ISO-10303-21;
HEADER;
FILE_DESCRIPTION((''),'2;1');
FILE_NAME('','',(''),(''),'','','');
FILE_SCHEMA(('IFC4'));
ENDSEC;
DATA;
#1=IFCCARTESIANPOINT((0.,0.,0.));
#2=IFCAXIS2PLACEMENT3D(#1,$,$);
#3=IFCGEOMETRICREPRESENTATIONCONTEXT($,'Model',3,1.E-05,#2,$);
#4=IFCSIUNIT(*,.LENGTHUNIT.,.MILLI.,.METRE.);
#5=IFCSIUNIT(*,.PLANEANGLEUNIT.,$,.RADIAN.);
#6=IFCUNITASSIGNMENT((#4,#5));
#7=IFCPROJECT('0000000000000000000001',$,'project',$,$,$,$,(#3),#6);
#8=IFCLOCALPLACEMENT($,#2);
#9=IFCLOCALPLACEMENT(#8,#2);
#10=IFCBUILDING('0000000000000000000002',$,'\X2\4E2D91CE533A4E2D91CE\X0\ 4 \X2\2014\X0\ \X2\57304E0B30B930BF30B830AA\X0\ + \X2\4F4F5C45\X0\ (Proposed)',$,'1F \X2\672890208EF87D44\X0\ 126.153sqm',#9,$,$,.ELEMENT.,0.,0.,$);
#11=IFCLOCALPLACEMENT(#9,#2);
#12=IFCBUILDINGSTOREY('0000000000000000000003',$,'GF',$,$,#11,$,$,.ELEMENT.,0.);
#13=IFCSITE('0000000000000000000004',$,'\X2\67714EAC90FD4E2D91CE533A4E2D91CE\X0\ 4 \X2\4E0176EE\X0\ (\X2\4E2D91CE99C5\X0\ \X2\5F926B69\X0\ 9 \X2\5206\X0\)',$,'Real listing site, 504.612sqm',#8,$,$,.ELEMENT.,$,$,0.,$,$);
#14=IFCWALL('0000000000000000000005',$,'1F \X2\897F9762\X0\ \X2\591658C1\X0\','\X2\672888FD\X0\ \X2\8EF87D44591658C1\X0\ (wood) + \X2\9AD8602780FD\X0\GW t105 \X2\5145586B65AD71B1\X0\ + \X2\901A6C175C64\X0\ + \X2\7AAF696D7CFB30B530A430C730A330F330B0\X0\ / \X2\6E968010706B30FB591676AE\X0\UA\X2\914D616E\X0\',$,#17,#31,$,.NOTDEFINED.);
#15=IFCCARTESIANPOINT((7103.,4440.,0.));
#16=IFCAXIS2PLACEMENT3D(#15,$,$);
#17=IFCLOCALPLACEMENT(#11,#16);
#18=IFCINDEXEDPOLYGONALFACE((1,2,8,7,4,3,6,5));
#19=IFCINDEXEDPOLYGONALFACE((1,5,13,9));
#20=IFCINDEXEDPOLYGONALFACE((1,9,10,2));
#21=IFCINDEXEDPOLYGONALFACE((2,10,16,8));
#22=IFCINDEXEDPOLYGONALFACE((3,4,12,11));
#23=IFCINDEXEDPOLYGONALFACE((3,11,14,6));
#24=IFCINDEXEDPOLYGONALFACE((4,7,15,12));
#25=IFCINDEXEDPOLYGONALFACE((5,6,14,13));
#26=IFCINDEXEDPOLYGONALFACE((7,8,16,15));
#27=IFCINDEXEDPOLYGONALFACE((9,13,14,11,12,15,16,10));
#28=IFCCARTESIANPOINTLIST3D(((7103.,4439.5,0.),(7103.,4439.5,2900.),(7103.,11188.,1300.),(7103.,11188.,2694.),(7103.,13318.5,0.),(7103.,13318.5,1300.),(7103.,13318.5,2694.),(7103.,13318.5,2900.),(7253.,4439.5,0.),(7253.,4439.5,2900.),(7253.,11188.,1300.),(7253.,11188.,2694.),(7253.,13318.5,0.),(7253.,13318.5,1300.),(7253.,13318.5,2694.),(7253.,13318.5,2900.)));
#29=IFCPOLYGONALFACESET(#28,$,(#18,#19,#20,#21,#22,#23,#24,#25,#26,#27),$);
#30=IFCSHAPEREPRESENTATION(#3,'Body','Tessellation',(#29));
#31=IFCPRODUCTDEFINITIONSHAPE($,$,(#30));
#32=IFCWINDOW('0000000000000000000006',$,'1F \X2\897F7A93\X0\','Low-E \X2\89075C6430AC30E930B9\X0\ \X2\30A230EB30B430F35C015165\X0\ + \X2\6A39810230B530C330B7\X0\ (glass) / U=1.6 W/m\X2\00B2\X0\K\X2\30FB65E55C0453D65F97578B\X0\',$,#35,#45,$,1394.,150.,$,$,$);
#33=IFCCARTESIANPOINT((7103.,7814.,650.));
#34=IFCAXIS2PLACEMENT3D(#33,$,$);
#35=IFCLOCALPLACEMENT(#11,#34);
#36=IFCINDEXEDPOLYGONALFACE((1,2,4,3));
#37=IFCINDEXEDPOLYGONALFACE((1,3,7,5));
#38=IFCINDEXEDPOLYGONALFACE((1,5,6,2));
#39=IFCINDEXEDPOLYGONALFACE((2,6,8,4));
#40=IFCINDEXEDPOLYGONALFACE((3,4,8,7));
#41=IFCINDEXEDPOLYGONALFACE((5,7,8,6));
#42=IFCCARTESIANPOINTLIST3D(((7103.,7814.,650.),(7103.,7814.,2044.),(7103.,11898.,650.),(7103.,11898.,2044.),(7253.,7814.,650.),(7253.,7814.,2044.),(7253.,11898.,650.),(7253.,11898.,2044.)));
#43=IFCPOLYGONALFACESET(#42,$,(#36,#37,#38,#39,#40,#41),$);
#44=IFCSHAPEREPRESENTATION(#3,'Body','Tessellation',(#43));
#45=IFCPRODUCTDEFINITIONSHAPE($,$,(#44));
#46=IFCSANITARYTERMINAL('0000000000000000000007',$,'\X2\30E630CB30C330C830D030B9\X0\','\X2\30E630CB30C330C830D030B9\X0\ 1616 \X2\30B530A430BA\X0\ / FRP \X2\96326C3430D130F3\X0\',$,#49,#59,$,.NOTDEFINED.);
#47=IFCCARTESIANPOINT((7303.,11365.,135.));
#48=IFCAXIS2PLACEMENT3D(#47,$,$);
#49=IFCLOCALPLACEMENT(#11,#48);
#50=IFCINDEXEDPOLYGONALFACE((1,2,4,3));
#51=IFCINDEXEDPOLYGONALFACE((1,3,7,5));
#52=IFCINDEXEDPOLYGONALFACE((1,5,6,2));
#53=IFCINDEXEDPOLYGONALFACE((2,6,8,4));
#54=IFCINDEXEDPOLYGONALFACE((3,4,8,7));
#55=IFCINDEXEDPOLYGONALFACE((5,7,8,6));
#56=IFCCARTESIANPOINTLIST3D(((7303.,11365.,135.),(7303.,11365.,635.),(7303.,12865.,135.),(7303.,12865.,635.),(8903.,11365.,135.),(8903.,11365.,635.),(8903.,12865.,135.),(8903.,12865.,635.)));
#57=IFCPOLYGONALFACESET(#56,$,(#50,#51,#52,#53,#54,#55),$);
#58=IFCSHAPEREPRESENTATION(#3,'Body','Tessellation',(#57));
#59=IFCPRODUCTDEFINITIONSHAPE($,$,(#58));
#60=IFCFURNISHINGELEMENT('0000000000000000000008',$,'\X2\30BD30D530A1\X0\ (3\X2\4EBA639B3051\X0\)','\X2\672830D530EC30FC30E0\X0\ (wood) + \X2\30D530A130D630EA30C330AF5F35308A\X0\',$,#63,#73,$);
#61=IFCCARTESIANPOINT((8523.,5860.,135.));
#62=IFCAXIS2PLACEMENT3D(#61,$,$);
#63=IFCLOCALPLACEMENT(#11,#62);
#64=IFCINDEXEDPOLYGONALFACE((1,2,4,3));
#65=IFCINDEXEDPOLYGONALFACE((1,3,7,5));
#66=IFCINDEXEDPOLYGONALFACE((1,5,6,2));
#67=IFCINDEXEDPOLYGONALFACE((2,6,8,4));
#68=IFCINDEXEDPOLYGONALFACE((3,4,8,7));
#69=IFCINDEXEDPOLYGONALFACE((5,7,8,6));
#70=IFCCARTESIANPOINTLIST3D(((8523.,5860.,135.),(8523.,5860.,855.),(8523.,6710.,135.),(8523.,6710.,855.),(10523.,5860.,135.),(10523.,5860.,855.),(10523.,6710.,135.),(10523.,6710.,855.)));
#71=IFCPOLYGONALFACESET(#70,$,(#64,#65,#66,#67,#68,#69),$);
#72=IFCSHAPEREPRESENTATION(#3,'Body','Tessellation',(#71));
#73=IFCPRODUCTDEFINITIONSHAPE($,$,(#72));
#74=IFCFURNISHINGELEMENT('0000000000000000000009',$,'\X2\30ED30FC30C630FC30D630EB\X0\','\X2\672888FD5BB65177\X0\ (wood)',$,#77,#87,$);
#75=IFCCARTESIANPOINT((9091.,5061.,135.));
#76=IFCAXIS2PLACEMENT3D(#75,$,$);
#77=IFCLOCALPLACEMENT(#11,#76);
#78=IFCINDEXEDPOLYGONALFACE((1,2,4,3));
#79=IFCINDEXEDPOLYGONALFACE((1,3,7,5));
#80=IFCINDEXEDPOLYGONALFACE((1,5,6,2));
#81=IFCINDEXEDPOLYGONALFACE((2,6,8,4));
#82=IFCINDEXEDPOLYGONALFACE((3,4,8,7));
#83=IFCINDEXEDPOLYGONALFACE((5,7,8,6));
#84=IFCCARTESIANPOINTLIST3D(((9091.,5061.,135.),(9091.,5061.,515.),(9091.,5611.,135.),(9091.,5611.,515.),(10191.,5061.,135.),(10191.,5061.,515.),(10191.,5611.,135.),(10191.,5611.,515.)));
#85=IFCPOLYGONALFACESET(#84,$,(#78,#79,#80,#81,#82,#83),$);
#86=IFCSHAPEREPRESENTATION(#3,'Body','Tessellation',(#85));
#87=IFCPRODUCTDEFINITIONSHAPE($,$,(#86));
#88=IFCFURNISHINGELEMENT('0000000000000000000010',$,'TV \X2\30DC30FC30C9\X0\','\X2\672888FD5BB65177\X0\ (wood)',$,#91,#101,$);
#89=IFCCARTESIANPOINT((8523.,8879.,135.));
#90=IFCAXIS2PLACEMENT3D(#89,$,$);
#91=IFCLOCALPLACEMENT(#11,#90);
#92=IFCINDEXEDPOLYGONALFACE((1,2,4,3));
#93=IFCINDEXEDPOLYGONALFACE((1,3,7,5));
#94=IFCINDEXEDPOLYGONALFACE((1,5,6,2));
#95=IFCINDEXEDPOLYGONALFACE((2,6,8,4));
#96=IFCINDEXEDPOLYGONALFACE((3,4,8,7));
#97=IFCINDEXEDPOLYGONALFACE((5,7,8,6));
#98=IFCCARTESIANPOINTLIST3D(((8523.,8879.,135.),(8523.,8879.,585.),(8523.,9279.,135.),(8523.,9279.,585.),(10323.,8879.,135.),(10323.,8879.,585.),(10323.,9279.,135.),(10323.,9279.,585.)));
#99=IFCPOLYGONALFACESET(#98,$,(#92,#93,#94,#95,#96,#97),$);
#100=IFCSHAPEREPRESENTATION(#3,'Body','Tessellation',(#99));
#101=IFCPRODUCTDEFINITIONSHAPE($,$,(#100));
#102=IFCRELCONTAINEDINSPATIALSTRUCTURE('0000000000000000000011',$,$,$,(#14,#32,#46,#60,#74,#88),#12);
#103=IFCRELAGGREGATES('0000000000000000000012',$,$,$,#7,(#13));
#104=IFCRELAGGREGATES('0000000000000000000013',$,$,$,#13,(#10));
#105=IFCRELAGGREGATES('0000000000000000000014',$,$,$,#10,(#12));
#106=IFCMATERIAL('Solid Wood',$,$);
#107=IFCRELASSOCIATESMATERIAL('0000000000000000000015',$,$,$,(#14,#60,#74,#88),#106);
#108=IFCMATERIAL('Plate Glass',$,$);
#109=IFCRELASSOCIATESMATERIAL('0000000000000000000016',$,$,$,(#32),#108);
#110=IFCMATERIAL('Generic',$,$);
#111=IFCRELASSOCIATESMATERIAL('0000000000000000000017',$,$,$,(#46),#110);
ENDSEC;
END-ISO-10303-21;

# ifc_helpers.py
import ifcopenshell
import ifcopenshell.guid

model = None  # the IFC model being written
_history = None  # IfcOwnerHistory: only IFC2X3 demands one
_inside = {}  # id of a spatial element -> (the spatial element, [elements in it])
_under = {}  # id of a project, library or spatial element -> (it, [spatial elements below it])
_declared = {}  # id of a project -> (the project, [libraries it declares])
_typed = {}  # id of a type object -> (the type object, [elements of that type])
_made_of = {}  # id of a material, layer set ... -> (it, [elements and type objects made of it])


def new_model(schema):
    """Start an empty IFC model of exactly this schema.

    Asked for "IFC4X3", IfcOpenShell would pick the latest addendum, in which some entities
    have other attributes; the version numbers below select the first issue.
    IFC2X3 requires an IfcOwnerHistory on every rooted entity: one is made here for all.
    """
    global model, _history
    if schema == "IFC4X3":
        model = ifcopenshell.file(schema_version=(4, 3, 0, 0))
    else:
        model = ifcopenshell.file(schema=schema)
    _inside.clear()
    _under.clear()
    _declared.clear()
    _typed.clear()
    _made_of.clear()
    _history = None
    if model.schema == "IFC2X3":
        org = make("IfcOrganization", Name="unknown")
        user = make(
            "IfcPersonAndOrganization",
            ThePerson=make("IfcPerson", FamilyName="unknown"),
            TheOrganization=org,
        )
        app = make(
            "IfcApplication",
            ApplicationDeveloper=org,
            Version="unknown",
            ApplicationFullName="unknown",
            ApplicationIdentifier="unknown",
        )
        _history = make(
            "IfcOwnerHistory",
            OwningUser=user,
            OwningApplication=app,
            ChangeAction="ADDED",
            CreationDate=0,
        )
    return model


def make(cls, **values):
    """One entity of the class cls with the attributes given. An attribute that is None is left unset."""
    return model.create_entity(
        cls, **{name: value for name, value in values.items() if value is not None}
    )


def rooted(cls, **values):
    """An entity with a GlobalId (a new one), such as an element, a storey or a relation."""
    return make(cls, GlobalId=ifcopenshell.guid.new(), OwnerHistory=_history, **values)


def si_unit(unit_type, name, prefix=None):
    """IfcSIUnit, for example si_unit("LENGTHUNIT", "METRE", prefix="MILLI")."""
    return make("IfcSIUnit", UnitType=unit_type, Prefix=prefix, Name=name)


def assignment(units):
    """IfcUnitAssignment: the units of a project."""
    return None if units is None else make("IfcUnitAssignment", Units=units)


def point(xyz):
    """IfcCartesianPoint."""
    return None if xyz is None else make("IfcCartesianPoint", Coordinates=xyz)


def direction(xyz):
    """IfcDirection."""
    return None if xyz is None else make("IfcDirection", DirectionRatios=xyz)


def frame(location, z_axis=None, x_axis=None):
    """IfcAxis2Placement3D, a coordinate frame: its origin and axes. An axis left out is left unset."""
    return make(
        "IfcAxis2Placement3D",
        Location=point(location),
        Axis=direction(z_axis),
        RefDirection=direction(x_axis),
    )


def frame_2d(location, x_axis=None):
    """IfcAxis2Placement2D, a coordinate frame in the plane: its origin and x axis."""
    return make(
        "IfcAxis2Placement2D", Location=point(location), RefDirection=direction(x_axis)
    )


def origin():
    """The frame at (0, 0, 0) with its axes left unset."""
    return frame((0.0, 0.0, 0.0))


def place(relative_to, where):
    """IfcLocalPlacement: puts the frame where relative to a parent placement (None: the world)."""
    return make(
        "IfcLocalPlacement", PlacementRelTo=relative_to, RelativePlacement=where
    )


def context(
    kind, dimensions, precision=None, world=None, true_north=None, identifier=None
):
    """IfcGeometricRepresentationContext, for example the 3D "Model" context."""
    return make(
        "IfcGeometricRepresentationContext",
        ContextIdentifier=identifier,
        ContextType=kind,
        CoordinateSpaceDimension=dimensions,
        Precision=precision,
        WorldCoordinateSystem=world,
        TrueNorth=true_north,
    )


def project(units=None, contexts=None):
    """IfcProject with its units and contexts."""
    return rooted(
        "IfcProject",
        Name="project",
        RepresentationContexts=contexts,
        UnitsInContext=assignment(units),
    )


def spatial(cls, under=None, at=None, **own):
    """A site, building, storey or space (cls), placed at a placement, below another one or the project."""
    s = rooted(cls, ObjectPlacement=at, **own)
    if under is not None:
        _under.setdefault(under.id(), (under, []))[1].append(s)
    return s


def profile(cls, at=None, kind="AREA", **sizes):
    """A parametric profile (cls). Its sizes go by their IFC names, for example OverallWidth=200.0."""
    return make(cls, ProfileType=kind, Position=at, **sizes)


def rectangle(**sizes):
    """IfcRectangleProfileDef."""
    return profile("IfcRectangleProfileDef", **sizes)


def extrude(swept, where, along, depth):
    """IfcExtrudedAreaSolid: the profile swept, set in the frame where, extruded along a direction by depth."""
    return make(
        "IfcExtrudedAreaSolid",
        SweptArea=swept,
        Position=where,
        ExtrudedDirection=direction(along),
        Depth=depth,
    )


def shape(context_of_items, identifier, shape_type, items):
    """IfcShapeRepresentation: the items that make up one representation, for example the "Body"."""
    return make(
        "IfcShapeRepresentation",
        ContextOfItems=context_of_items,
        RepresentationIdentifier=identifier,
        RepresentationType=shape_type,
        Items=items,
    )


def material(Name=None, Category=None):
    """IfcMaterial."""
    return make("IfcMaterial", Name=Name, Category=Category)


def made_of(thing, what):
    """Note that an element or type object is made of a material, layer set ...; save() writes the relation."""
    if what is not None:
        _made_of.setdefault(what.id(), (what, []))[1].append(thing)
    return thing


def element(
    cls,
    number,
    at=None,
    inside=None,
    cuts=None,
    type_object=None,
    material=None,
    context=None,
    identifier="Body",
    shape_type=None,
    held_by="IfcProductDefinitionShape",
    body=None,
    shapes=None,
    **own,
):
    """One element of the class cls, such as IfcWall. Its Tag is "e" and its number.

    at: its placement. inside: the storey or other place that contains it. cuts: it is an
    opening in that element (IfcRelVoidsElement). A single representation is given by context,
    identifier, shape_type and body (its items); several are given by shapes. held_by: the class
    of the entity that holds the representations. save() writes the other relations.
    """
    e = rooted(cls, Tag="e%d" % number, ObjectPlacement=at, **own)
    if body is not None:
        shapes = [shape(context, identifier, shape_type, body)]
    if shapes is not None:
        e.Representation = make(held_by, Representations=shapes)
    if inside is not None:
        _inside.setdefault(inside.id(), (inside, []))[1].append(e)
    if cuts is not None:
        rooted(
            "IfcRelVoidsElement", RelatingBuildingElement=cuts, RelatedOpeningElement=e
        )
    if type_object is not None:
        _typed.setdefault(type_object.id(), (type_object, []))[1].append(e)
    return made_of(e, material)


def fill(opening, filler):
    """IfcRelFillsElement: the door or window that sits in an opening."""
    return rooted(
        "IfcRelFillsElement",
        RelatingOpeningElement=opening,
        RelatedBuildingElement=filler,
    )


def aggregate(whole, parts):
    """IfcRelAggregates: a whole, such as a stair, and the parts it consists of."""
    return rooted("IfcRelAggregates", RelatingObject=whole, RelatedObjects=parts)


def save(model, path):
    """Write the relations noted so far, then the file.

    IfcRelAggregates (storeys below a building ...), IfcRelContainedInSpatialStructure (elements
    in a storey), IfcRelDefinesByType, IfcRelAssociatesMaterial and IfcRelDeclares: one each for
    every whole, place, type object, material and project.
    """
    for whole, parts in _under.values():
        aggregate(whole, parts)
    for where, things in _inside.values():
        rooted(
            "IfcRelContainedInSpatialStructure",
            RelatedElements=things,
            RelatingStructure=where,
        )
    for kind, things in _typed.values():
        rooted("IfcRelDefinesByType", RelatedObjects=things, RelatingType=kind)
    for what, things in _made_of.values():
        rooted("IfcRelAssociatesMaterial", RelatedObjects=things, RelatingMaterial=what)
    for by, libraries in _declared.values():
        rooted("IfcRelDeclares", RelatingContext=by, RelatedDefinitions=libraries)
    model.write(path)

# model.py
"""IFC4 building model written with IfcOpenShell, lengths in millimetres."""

from ifc_helpers import new_model, si_unit, frame, frame_2d, origin, place, context, project, spatial, rectangle, extrude, material, element, fill, save


model = new_model("IFC4")

# Units and contexts
model_context = context("Model", 3, precision=1e-05, world=origin())
ifc_project = project(units=[si_unit("LENGTHUNIT", "METRE", prefix="MILLI"), si_unit("PLANEANGLEUNIT", "RADIAN")], contexts=[model_context])

# Site, building, storey
site_placement = place(None, origin())
site = spatial("IfcSite", under=ifc_project, at=site_placement, Name="東京都中野区中野 4 丁目 (中野駅 徒歩 9 分)", ObjectType="Real listing site, 504.612sqm", CompositionType="ELEMENT", RefElevation=0.0)
building_placement = place(site_placement, origin())
building = spatial("IfcBuilding", under=site, at=building_placement, Name="中野区中野 4 — 地下スタジオ + 住居 (Proposed)", ObjectType="1F 木造軸組 126.153sqm", CompositionType="ELEMENT", ElevationOfRefHeight=0.0, ElevationOfTerrain=0.0)
storey_placement = place(building_placement, origin())
storey = spatial("IfcBuildingStorey", under=building, at=storey_placement, Name="GF", CompositionType="ELEMENT", Elevation=0.0)

# Shared definitions
ifc_material_1 = material(Name="Solid Wood")

# Shared definitions
ifc_material_2 = material(Name="Plate Glass")

# Wall, opening, window
wall_1_placement = place(storey_placement, frame((7103.0, 4440.0, 0.0)))
wall_1 = element("IfcWall", 1, at=wall_1_placement, inside=storey, material=ifc_material_1, Name="1F 西面 外壁", Description="木製 軸組外壁 (wood) + 高性能GW t105 充填断熱 + 通気層 + 窯業系サイディング / 準耐火・外皮UA配慮", PredefinedType="NOTDEFINED", context=model_context, shape_type="SweptSolid", body=[
    extrude(rectangle(XDim=150.0, YDim=8879.0, at=frame_2d((75.0, 4439.0))), frame((7103.0, 4440.0, 0.0)), (0.0, 0.0, 1.0), 2900.0),
])
opening_1_placement = place(storey_placement, frame((7103.0, 7814.0, 650.0)))
opening_1 = element("IfcOpeningElement", 2, at=opening_1_placement, cuts=wall_1, PredefinedType="NOTDEFINED", context=model_context, shape_type="SweptSolid", body=[
    extrude(rectangle(XDim=150.0, YDim=4084.0, at=frame_2d((75.0, 2042.0))), frame((7103.0, 7814.0, 650.0)), (0.0, 0.0, 1.0), 1394.0),
])
window_1_placement = place(storey_placement, frame((7103.0, 7814.0, 650.0)))
window_1 = element("IfcWindow", 3, at=window_1_placement, inside=storey, material=ifc_material_2, Name="1F 西窓", Description="Low-E 複層ガラス アルゴン封入 + 樹脂サッシ (glass) / U=1.6 W/m²K・日射取得型", OverallHeight=1394.0, OverallWidth=150.0, context=model_context, shape_type="SweptSolid", body=[
    extrude(rectangle(XDim=150.0, YDim=4084.0, at=frame_2d((75.0, 2042.0))), frame((7103.0, 7814.0, 650.0)), (0.0, 0.0, 1.0), 1394.0),
])
fill(opening_1, window_1)

# Shared definitions
ifc_material_3 = material(Name="Generic")

# Sanitary terminal
sanitary_terminal_placement = place(storey_placement, frame((7303.0, 11365.0, 135.0)))
element("IfcSanitaryTerminal", 4, at=sanitary_terminal_placement, inside=storey, material=ifc_material_3, Name="ユニットバス", Description="ユニットバス 1616 サイズ / FRP 防水パン", PredefinedType="NOTDEFINED", context=model_context, shape_type="SweptSolid", body=[
    extrude(rectangle(XDim=1600.0, YDim=1500.0, at=frame_2d((800.0, 750.0))), frame((7303.0, 11365.0, 135.0)), (0.0, 0.0, 1.0), 500.0),
])

# Furnishing elements
furnishing_1_placement = place(storey_placement, frame((8523.0, 5860.0, 135.0)))
element("IfcFurnishingElement", 5, at=furnishing_1_placement, inside=storey, material=ifc_material_1, Name="ソファ (3人掛け)", Description="木フレーム (wood) + ファブリック張り", context=model_context, shape_type="SweptSolid", body=[
    extrude(rectangle(XDim=2000.0, YDim=850.0, at=frame_2d((1000.0, 425.0))), frame((8523.0, 5860.0, 135.0)), (0.0, 0.0, 1.0), 720.0),
])
furnishing_2_placement = place(storey_placement, frame((9091.0, 5061.0, 135.0)))
element("IfcFurnishingElement", 6, at=furnishing_2_placement, inside=storey, material=ifc_material_1, Name="ローテーブル", Description="木製家具 (wood)", context=model_context, shape_type="SweptSolid", body=[
    extrude(rectangle(XDim=1100.0, YDim=550.0, at=frame_2d((550.0, 275.0))), frame((9091.0, 5061.0, 135.0)), (0.0, 0.0, 1.0), 380.0),
])
furnishing_3_placement = place(storey_placement, frame((8523.0, 8879.0, 135.0)))
element("IfcFurnishingElement", 7, at=furnishing_3_placement, inside=storey, material=ifc_material_1, Name="TV ボード", Description="木製家具 (wood)", context=model_context, shape_type="SweptSolid", body=[
    extrude(rectangle(XDim=1800.0, YDim=400.0, at=frame_2d((900.0, 200.0))), frame((8523.0, 8879.0, 135.0)), (0.0, 0.0, 1.0), 450.0),
])

save(model, "model.ifc")
